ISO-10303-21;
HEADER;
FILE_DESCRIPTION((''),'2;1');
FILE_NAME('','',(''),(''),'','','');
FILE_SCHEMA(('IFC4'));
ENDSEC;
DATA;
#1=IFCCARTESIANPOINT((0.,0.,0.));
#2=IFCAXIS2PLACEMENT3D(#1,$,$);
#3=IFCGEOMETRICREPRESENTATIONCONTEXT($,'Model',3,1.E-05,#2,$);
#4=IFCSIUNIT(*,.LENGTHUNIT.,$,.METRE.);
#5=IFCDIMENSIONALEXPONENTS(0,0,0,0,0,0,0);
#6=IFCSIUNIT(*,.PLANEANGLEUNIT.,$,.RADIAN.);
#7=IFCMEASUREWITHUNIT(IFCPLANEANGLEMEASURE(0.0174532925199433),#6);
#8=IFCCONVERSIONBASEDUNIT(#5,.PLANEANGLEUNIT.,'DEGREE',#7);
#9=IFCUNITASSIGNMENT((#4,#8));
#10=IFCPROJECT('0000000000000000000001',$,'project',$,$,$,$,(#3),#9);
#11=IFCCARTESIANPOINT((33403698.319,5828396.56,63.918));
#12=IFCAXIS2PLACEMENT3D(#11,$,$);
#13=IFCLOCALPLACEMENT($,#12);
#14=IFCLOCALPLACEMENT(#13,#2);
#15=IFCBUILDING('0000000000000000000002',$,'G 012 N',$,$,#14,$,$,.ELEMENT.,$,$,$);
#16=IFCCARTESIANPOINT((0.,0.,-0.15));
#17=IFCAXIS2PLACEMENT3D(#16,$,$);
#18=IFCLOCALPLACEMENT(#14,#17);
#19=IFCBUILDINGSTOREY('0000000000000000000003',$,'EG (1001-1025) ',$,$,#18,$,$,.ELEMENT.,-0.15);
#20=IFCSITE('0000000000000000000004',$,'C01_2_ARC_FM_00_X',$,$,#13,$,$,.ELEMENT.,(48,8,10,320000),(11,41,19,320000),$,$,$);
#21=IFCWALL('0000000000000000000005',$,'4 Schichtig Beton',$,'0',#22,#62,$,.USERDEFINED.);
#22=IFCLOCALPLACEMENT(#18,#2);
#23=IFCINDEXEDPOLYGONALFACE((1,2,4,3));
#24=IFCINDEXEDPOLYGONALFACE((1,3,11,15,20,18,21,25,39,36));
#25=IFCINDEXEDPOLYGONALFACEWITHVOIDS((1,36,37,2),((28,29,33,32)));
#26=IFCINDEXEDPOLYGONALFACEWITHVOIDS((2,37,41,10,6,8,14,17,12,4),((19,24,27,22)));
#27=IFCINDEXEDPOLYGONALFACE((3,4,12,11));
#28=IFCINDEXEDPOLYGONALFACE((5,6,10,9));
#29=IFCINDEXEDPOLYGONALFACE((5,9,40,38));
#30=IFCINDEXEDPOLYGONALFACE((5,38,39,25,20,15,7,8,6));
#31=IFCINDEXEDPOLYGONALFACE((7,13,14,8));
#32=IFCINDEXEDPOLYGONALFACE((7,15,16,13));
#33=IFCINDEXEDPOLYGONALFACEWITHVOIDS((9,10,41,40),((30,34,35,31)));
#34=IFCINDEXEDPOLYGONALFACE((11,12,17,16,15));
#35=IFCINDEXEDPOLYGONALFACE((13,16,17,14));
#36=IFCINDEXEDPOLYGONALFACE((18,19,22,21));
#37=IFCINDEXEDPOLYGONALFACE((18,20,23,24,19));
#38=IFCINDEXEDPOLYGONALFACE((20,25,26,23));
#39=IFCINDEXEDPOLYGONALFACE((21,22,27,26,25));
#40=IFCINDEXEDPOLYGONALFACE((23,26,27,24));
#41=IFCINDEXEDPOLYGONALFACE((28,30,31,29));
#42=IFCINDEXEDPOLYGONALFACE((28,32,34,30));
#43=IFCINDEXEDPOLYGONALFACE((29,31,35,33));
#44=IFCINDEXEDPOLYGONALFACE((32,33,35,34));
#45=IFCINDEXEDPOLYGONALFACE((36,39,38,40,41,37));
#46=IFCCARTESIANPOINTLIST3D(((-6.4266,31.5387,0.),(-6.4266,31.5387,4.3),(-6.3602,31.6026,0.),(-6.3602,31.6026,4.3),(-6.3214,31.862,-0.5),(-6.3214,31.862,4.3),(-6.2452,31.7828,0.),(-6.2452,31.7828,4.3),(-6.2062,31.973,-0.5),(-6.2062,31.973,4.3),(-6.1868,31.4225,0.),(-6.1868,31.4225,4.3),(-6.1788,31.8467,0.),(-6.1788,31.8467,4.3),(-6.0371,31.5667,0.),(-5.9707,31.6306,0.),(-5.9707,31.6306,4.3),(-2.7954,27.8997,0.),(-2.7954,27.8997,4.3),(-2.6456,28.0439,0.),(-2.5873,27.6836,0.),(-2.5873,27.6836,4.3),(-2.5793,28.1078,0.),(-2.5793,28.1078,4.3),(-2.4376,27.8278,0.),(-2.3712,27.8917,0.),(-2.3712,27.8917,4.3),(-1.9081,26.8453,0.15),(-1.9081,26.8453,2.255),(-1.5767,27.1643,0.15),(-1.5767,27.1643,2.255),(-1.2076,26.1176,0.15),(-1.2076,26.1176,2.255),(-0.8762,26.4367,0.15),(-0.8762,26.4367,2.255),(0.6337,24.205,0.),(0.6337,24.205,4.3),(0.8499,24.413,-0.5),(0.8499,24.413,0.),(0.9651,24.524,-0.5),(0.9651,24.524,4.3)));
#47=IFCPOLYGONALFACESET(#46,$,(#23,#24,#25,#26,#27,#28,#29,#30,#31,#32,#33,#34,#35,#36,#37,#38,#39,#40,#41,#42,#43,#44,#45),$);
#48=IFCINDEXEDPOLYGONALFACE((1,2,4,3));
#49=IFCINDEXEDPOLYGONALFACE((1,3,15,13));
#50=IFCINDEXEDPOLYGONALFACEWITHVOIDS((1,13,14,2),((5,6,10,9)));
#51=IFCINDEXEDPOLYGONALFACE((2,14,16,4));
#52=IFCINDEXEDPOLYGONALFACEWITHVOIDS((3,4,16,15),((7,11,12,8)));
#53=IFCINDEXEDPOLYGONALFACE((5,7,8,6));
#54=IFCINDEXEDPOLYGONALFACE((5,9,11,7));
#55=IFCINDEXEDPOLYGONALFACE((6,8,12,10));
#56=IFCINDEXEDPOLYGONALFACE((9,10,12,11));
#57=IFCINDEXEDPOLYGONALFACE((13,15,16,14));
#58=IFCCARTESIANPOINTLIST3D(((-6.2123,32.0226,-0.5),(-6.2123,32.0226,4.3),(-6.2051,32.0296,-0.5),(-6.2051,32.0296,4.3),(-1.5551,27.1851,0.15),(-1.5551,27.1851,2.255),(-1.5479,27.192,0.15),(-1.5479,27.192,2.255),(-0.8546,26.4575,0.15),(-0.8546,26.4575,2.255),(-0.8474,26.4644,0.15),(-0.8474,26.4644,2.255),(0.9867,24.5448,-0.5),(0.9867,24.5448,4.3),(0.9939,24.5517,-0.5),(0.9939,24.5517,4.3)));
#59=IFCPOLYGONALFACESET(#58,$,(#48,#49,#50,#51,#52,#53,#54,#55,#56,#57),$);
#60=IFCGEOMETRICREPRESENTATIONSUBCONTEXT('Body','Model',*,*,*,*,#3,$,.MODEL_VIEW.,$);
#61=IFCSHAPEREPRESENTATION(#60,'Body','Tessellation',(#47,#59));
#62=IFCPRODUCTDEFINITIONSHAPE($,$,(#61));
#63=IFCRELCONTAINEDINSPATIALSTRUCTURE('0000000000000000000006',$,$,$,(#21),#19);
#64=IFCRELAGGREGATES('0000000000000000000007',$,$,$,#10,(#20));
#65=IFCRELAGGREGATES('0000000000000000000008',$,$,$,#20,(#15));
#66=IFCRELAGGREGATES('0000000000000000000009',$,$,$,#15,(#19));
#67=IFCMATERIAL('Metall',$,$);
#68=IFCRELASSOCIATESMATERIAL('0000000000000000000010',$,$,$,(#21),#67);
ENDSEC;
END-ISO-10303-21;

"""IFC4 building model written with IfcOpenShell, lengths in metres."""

from ifc_helpers import new_model, entity, si_unit, converted_unit, frame, frame_2d, origin, origin_with_axes, place, context, subcontext, project, spatial, polyline, rectangle, outline, extrude, clip, bounded_halfspace, material, element, save


model = new_model("IFC4")

# Units and contexts
model_context = context("Model", 3, precision=1e-05, world=origin())
body_context = subcontext(model_context, "Body", "Model", "MODEL_VIEW")
ifc_project = project(units=[si_unit("LENGTHUNIT", "METRE"), converted_unit("PLANEANGLEUNIT", "DEGREE", entity("IfcPlaneAngleMeasure", 0.0174532925199433), si_unit("PLANEANGLEUNIT", "RADIAN"), dimensions=[0, 0, 0, 0, 0, 0, 0])], contexts=[model_context])

# Site, building, storey
site_placement = place(None, frame((33403698.319, 5828396.56, 63.918)))
site = spatial("IfcSite", under=ifc_project, at=site_placement, Name="C01_2_ARC_FM_00_X", CompositionType="ELEMENT", RefLatitude=(48, 8, 10, 320000), RefLongitude=(11, 41, 19, 320000))
building_placement = place(site_placement, origin())
building = spatial("IfcBuilding", under=site, at=building_placement, Name="G 012 N", CompositionType="ELEMENT")
storey_placement = place(building_placement, frame((0.0, 0.0, -0.15)))
storey = spatial("IfcBuildingStorey", under=building, at=storey_placement, Name="EG (1001-1025) ", CompositionType="ELEMENT", Elevation=-0.15)

# Wall, opening
ifc_material_1 = material(Name="Metall")
wall_1_placement = place(storey_placement, frame((0.9939, 24.5517, -0.5), z_axis=(0.0, 0.0, 1.0), x_axis=(-0.693551, 0.720408, 0.0)))
wall_1 = element("IfcWall", 1, at=wall_1_placement, inside=storey, material=ifc_material_1, Name="4 Schichtig Beton", ObjectType="0", PredefinedType="USERDEFINED", context=body_context, shape_type="Clipping", body=[
    clip(clip(clip(extrude(outline(polyline([(5.4433, -5.5463), (5.4433, -5.3863), (5.0333, -5.3863), (5.0333, -5.1785), (5.2833, -5.1785), (5.2833, -5.0863), (-4.8967, -5.0863), (-4.8967, -5.5463), (5.4433, -5.5463)]), holes=[polyline([(0.1433, -5.3863), (-0.1567, -5.3863), (-0.1567, -5.1785), (0.1433, -5.1785), (0.1433, -5.3863)])]), frame((4.8967, 5.5863, 0.0), z_axis=(0.0, 0.0, 1.0), x_axis=(1.0, 0.0, 0.0)), (0.0, 0.0, 1.0), 4.8), bounded_halfspace(frame((5.978, 0.3431, 0.5), z_axis=(0.0, 0.0, 1.0), x_axis=(0.0, -1.0, 0.0)), True, origin_with_axes(), polyline([(5.04, 0.4079), (5.04, 0.2), (9.93, 0.2), (9.93, 0.4079), (10.18, 0.4079), (10.18, 0.5), (0.0, 0.5), (0.0, 0.2), (4.74, 0.2), (4.74, 0.4079), (5.04, 0.4079)]))), bounded_halfspace(frame((10.08, 0.1539, 0.5), z_axis=(0.0, 0.0, -1.0), x_axis=(-1.0, 0.0, 0.0)), True, origin_with_axes(), polyline([(10.23, 0.2), (9.93, 0.2), (9.93, 0.1079), (10.23, 0.1079), (10.23, 0.2)]))), bounded_halfspace(frame((4.89, 0.1539, 0.5), z_axis=(0.0, 0.0, -1.0), x_axis=(-1.0, 0.0, 0.0)), True, origin_with_axes(), polyline([(5.04, 0.2), (4.74, 0.2), (4.74, 0.1079), (5.04, 0.1079), (5.04, 0.2)]))),
    clip(clip(clip(extrude(rectangle(XDim=10.38, YDim=0.01, at=frame_2d((-5.19, -0.005), x_axis=(-1.0, 0.0))), frame((10.38, 0.01, 0.0), z_axis=(0.0, 0.0, 1.0), x_axis=(1.0, 0.0, 0.0)), (0.0, 0.0, 1.0), 4.8), bounded_halfspace(frame((5.978, 0.3431, 0.5), z_axis=(0.0, 0.0, 1.0), x_axis=(0.0, -1.0, 0.0)), True, origin_with_axes(), polyline([(5.04, 0.4079), (5.04, 0.2), (9.93, 0.2), (9.93, 0.4079), (10.18, 0.4079), (10.18, 0.5), (0.0, 0.5), (0.0, 0.2), (4.74, 0.2), (4.74, 0.4079), (5.04, 0.4079)]))), bounded_halfspace(frame((10.08, 0.1539, 0.5), z_axis=(0.0, 0.0, -1.0), x_axis=(-1.0, 0.0, 0.0)), True, origin_with_axes(), polyline([(10.23, 0.2), (9.93, 0.2), (9.93, 0.1079), (10.23, 0.1079), (10.23, 0.2)]))), bounded_halfspace(frame((4.89, 0.1539, 0.5), z_axis=(0.0, 0.0, -1.0), x_axis=(-1.0, 0.0, 0.0)), True, origin_with_axes(), polyline([(5.04, 0.2), (4.74, 0.2), (4.74, 0.1079), (5.04, 0.1079), (5.04, 0.2)]))),
])
opening_1_placement = place(wall_1_placement, frame((2.655, 0.0, 0.65), z_axis=(0.0, 1.0, 0.0), x_axis=(0.0, 0.0, 1.0)))
element("IfcOpeningElement", 2, at=opening_1_placement, cuts=wall_1, ObjectType="Opening", context=body_context, shape_type="SweptSolid", body=[
    extrude(outline(polyline([(0.0, 1.01), (2.105, 1.01), (2.105, 0.0), (0.0, 0.0), (0.0, 1.01)])), origin_with_axes(), (0.0, 0.0, 1.0), 0.01),
    extrude(outline(polyline([(0.0, 1.01), (2.105, 1.01), (2.105, 0.0), (0.0, 0.0), (0.0, 1.01)])), frame((0.0, 0.0, 0.01), z_axis=(0.0, 0.0, 1.0), x_axis=(1.0, 0.0, 0.0)), (0.0, 0.0, 1.0), 0.03),
    extrude(outline(polyline([(0.0, 1.01), (2.105, 1.01), (2.105, 0.0), (0.0, 0.0), (0.0, 1.01)])), frame((0.0, 0.0, 0.04), z_axis=(0.0, 0.0, 1.0), x_axis=(1.0, 0.0, 0.0)), (0.0, 0.0, 1.0), 0.16),
    extrude(outline(polyline([(0.0, 1.01), (2.105, 1.01), (2.105, 0.0), (0.0, 0.0), (0.0, 1.01)])), frame((0.0, 0.0, 0.2), z_axis=(0.0, 0.0, 1.0), x_axis=(1.0, 0.0, 0.0)), (0.0, 0.0, 1.0), 0.3),
])

save(model, "model.ifc")
